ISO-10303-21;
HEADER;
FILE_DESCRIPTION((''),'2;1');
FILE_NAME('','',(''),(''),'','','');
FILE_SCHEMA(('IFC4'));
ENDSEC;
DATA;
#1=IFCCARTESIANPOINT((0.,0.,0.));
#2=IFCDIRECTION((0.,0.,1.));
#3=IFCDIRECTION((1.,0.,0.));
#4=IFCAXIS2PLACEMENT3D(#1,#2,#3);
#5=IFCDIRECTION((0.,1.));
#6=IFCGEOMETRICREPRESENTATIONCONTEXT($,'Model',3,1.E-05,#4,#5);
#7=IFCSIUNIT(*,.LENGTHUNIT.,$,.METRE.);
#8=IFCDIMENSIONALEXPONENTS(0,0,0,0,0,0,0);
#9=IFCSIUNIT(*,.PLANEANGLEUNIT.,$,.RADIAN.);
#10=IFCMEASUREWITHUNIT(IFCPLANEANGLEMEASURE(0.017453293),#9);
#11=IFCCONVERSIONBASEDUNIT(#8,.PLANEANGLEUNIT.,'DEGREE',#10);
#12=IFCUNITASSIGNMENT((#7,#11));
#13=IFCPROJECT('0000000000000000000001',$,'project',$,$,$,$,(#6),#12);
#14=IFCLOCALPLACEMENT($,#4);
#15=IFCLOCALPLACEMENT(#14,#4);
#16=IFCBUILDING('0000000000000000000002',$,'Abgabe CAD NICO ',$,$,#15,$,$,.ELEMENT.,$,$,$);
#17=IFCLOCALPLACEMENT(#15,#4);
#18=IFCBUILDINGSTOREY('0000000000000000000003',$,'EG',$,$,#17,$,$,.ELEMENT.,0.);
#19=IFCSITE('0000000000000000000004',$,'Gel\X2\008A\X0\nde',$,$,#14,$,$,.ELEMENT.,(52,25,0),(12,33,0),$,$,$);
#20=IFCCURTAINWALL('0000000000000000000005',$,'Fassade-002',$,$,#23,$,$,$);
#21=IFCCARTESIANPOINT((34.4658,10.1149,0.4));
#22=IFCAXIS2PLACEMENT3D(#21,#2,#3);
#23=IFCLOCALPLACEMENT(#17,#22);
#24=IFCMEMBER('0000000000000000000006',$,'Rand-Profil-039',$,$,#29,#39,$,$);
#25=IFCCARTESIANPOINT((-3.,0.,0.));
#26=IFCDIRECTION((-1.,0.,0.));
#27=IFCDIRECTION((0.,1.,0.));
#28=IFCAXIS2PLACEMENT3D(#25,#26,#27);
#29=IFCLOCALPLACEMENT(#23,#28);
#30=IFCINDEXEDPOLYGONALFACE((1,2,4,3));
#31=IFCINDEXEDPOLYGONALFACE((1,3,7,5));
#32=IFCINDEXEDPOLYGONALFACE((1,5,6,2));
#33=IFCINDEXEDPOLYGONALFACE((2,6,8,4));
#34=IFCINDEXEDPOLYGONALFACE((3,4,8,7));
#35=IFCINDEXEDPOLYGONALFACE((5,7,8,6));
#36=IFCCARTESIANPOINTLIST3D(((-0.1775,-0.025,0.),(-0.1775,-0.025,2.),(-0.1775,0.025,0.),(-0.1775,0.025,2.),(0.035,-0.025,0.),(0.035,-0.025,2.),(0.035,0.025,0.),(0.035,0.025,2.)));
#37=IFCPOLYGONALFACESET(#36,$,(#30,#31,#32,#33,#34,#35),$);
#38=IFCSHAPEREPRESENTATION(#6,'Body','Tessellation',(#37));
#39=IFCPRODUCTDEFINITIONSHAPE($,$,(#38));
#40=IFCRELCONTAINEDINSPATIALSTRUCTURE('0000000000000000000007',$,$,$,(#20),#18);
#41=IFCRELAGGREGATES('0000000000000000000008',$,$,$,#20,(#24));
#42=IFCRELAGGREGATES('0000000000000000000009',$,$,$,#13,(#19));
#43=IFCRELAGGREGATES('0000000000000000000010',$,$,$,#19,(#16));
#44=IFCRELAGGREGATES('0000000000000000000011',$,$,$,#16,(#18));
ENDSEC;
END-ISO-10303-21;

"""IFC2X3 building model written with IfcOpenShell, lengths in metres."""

from ifc_helpers import new_model, entity, si_unit, converted_unit, direction, frame, origin_with_axes, place, context, project, spatial, polyline, outline, extrude, element, aggregate, save


model = new_model("IFC2X3")

# Units and contexts
model_context = context("Model", 3, precision=1e-05, world=origin_with_axes(), true_north=direction((0.0, 1.0)))
ifc_project = project(units=[si_unit("LENGTHUNIT", "METRE"), converted_unit("PLANEANGLEUNIT", "DEGREE", entity("IfcPlaneAngleMeasure", 0.017453293), si_unit("PLANEANGLEUNIT", "RADIAN"), dimensions=[0, 0, 0, 0, 0, 0, 0])], contexts=[model_context])

# Site, building, storey
site_placement = place(None, origin_with_axes())
site = spatial("IfcSite", under=ifc_project, at=site_placement, Name="Gel\u008ande", CompositionType="ELEMENT", RefLatitude=(52, 25, 0), RefLongitude=(12, 33, 0))
building_placement = place(site_placement, origin_with_axes())
building = spatial("IfcBuilding", under=site, at=building_placement, Name="Abgabe CAD NICO ", CompositionType="ELEMENT")
storey_placement = place(building_placement, origin_with_axes())
storey = spatial("IfcBuildingStorey", under=building, at=storey_placement, Name="EG", CompositionType="ELEMENT", Elevation=0.0)

# Curtain wall, member
curtain_wall_placement = place(storey_placement, frame((34.4658, 10.1149, 0.4), z_axis=(0.0, 0.0, 1.0), x_axis=(1.0, 0.0, 0.0)))
curtain_wall = element("IfcCurtainWall", 1, at=curtain_wall_placement, inside=storey, Name="Fassade-002")
member_1_placement = place(curtain_wall_placement, frame((-3.0, 0.0, 0.0), z_axis=(-1.0, 0.0, 0.0), x_axis=(0.0, 1.0, 0.0)))
member_1 = element("IfcMember", 2, at=member_1_placement, Name="Rand-Profil-039", context=model_context, shape_type="SweptSolid", body=[
    extrude(outline(polyline([(-0.1775, -0.025), (0.035, -0.025), (0.035, 0.025), (-0.1775, 0.025), (-0.1775, -0.025)])), origin_with_axes(), (0.0, 0.0, 1.0), 2.0),
])

aggregate(curtain_wall, [member_1])

save(model, "model.ifc")
